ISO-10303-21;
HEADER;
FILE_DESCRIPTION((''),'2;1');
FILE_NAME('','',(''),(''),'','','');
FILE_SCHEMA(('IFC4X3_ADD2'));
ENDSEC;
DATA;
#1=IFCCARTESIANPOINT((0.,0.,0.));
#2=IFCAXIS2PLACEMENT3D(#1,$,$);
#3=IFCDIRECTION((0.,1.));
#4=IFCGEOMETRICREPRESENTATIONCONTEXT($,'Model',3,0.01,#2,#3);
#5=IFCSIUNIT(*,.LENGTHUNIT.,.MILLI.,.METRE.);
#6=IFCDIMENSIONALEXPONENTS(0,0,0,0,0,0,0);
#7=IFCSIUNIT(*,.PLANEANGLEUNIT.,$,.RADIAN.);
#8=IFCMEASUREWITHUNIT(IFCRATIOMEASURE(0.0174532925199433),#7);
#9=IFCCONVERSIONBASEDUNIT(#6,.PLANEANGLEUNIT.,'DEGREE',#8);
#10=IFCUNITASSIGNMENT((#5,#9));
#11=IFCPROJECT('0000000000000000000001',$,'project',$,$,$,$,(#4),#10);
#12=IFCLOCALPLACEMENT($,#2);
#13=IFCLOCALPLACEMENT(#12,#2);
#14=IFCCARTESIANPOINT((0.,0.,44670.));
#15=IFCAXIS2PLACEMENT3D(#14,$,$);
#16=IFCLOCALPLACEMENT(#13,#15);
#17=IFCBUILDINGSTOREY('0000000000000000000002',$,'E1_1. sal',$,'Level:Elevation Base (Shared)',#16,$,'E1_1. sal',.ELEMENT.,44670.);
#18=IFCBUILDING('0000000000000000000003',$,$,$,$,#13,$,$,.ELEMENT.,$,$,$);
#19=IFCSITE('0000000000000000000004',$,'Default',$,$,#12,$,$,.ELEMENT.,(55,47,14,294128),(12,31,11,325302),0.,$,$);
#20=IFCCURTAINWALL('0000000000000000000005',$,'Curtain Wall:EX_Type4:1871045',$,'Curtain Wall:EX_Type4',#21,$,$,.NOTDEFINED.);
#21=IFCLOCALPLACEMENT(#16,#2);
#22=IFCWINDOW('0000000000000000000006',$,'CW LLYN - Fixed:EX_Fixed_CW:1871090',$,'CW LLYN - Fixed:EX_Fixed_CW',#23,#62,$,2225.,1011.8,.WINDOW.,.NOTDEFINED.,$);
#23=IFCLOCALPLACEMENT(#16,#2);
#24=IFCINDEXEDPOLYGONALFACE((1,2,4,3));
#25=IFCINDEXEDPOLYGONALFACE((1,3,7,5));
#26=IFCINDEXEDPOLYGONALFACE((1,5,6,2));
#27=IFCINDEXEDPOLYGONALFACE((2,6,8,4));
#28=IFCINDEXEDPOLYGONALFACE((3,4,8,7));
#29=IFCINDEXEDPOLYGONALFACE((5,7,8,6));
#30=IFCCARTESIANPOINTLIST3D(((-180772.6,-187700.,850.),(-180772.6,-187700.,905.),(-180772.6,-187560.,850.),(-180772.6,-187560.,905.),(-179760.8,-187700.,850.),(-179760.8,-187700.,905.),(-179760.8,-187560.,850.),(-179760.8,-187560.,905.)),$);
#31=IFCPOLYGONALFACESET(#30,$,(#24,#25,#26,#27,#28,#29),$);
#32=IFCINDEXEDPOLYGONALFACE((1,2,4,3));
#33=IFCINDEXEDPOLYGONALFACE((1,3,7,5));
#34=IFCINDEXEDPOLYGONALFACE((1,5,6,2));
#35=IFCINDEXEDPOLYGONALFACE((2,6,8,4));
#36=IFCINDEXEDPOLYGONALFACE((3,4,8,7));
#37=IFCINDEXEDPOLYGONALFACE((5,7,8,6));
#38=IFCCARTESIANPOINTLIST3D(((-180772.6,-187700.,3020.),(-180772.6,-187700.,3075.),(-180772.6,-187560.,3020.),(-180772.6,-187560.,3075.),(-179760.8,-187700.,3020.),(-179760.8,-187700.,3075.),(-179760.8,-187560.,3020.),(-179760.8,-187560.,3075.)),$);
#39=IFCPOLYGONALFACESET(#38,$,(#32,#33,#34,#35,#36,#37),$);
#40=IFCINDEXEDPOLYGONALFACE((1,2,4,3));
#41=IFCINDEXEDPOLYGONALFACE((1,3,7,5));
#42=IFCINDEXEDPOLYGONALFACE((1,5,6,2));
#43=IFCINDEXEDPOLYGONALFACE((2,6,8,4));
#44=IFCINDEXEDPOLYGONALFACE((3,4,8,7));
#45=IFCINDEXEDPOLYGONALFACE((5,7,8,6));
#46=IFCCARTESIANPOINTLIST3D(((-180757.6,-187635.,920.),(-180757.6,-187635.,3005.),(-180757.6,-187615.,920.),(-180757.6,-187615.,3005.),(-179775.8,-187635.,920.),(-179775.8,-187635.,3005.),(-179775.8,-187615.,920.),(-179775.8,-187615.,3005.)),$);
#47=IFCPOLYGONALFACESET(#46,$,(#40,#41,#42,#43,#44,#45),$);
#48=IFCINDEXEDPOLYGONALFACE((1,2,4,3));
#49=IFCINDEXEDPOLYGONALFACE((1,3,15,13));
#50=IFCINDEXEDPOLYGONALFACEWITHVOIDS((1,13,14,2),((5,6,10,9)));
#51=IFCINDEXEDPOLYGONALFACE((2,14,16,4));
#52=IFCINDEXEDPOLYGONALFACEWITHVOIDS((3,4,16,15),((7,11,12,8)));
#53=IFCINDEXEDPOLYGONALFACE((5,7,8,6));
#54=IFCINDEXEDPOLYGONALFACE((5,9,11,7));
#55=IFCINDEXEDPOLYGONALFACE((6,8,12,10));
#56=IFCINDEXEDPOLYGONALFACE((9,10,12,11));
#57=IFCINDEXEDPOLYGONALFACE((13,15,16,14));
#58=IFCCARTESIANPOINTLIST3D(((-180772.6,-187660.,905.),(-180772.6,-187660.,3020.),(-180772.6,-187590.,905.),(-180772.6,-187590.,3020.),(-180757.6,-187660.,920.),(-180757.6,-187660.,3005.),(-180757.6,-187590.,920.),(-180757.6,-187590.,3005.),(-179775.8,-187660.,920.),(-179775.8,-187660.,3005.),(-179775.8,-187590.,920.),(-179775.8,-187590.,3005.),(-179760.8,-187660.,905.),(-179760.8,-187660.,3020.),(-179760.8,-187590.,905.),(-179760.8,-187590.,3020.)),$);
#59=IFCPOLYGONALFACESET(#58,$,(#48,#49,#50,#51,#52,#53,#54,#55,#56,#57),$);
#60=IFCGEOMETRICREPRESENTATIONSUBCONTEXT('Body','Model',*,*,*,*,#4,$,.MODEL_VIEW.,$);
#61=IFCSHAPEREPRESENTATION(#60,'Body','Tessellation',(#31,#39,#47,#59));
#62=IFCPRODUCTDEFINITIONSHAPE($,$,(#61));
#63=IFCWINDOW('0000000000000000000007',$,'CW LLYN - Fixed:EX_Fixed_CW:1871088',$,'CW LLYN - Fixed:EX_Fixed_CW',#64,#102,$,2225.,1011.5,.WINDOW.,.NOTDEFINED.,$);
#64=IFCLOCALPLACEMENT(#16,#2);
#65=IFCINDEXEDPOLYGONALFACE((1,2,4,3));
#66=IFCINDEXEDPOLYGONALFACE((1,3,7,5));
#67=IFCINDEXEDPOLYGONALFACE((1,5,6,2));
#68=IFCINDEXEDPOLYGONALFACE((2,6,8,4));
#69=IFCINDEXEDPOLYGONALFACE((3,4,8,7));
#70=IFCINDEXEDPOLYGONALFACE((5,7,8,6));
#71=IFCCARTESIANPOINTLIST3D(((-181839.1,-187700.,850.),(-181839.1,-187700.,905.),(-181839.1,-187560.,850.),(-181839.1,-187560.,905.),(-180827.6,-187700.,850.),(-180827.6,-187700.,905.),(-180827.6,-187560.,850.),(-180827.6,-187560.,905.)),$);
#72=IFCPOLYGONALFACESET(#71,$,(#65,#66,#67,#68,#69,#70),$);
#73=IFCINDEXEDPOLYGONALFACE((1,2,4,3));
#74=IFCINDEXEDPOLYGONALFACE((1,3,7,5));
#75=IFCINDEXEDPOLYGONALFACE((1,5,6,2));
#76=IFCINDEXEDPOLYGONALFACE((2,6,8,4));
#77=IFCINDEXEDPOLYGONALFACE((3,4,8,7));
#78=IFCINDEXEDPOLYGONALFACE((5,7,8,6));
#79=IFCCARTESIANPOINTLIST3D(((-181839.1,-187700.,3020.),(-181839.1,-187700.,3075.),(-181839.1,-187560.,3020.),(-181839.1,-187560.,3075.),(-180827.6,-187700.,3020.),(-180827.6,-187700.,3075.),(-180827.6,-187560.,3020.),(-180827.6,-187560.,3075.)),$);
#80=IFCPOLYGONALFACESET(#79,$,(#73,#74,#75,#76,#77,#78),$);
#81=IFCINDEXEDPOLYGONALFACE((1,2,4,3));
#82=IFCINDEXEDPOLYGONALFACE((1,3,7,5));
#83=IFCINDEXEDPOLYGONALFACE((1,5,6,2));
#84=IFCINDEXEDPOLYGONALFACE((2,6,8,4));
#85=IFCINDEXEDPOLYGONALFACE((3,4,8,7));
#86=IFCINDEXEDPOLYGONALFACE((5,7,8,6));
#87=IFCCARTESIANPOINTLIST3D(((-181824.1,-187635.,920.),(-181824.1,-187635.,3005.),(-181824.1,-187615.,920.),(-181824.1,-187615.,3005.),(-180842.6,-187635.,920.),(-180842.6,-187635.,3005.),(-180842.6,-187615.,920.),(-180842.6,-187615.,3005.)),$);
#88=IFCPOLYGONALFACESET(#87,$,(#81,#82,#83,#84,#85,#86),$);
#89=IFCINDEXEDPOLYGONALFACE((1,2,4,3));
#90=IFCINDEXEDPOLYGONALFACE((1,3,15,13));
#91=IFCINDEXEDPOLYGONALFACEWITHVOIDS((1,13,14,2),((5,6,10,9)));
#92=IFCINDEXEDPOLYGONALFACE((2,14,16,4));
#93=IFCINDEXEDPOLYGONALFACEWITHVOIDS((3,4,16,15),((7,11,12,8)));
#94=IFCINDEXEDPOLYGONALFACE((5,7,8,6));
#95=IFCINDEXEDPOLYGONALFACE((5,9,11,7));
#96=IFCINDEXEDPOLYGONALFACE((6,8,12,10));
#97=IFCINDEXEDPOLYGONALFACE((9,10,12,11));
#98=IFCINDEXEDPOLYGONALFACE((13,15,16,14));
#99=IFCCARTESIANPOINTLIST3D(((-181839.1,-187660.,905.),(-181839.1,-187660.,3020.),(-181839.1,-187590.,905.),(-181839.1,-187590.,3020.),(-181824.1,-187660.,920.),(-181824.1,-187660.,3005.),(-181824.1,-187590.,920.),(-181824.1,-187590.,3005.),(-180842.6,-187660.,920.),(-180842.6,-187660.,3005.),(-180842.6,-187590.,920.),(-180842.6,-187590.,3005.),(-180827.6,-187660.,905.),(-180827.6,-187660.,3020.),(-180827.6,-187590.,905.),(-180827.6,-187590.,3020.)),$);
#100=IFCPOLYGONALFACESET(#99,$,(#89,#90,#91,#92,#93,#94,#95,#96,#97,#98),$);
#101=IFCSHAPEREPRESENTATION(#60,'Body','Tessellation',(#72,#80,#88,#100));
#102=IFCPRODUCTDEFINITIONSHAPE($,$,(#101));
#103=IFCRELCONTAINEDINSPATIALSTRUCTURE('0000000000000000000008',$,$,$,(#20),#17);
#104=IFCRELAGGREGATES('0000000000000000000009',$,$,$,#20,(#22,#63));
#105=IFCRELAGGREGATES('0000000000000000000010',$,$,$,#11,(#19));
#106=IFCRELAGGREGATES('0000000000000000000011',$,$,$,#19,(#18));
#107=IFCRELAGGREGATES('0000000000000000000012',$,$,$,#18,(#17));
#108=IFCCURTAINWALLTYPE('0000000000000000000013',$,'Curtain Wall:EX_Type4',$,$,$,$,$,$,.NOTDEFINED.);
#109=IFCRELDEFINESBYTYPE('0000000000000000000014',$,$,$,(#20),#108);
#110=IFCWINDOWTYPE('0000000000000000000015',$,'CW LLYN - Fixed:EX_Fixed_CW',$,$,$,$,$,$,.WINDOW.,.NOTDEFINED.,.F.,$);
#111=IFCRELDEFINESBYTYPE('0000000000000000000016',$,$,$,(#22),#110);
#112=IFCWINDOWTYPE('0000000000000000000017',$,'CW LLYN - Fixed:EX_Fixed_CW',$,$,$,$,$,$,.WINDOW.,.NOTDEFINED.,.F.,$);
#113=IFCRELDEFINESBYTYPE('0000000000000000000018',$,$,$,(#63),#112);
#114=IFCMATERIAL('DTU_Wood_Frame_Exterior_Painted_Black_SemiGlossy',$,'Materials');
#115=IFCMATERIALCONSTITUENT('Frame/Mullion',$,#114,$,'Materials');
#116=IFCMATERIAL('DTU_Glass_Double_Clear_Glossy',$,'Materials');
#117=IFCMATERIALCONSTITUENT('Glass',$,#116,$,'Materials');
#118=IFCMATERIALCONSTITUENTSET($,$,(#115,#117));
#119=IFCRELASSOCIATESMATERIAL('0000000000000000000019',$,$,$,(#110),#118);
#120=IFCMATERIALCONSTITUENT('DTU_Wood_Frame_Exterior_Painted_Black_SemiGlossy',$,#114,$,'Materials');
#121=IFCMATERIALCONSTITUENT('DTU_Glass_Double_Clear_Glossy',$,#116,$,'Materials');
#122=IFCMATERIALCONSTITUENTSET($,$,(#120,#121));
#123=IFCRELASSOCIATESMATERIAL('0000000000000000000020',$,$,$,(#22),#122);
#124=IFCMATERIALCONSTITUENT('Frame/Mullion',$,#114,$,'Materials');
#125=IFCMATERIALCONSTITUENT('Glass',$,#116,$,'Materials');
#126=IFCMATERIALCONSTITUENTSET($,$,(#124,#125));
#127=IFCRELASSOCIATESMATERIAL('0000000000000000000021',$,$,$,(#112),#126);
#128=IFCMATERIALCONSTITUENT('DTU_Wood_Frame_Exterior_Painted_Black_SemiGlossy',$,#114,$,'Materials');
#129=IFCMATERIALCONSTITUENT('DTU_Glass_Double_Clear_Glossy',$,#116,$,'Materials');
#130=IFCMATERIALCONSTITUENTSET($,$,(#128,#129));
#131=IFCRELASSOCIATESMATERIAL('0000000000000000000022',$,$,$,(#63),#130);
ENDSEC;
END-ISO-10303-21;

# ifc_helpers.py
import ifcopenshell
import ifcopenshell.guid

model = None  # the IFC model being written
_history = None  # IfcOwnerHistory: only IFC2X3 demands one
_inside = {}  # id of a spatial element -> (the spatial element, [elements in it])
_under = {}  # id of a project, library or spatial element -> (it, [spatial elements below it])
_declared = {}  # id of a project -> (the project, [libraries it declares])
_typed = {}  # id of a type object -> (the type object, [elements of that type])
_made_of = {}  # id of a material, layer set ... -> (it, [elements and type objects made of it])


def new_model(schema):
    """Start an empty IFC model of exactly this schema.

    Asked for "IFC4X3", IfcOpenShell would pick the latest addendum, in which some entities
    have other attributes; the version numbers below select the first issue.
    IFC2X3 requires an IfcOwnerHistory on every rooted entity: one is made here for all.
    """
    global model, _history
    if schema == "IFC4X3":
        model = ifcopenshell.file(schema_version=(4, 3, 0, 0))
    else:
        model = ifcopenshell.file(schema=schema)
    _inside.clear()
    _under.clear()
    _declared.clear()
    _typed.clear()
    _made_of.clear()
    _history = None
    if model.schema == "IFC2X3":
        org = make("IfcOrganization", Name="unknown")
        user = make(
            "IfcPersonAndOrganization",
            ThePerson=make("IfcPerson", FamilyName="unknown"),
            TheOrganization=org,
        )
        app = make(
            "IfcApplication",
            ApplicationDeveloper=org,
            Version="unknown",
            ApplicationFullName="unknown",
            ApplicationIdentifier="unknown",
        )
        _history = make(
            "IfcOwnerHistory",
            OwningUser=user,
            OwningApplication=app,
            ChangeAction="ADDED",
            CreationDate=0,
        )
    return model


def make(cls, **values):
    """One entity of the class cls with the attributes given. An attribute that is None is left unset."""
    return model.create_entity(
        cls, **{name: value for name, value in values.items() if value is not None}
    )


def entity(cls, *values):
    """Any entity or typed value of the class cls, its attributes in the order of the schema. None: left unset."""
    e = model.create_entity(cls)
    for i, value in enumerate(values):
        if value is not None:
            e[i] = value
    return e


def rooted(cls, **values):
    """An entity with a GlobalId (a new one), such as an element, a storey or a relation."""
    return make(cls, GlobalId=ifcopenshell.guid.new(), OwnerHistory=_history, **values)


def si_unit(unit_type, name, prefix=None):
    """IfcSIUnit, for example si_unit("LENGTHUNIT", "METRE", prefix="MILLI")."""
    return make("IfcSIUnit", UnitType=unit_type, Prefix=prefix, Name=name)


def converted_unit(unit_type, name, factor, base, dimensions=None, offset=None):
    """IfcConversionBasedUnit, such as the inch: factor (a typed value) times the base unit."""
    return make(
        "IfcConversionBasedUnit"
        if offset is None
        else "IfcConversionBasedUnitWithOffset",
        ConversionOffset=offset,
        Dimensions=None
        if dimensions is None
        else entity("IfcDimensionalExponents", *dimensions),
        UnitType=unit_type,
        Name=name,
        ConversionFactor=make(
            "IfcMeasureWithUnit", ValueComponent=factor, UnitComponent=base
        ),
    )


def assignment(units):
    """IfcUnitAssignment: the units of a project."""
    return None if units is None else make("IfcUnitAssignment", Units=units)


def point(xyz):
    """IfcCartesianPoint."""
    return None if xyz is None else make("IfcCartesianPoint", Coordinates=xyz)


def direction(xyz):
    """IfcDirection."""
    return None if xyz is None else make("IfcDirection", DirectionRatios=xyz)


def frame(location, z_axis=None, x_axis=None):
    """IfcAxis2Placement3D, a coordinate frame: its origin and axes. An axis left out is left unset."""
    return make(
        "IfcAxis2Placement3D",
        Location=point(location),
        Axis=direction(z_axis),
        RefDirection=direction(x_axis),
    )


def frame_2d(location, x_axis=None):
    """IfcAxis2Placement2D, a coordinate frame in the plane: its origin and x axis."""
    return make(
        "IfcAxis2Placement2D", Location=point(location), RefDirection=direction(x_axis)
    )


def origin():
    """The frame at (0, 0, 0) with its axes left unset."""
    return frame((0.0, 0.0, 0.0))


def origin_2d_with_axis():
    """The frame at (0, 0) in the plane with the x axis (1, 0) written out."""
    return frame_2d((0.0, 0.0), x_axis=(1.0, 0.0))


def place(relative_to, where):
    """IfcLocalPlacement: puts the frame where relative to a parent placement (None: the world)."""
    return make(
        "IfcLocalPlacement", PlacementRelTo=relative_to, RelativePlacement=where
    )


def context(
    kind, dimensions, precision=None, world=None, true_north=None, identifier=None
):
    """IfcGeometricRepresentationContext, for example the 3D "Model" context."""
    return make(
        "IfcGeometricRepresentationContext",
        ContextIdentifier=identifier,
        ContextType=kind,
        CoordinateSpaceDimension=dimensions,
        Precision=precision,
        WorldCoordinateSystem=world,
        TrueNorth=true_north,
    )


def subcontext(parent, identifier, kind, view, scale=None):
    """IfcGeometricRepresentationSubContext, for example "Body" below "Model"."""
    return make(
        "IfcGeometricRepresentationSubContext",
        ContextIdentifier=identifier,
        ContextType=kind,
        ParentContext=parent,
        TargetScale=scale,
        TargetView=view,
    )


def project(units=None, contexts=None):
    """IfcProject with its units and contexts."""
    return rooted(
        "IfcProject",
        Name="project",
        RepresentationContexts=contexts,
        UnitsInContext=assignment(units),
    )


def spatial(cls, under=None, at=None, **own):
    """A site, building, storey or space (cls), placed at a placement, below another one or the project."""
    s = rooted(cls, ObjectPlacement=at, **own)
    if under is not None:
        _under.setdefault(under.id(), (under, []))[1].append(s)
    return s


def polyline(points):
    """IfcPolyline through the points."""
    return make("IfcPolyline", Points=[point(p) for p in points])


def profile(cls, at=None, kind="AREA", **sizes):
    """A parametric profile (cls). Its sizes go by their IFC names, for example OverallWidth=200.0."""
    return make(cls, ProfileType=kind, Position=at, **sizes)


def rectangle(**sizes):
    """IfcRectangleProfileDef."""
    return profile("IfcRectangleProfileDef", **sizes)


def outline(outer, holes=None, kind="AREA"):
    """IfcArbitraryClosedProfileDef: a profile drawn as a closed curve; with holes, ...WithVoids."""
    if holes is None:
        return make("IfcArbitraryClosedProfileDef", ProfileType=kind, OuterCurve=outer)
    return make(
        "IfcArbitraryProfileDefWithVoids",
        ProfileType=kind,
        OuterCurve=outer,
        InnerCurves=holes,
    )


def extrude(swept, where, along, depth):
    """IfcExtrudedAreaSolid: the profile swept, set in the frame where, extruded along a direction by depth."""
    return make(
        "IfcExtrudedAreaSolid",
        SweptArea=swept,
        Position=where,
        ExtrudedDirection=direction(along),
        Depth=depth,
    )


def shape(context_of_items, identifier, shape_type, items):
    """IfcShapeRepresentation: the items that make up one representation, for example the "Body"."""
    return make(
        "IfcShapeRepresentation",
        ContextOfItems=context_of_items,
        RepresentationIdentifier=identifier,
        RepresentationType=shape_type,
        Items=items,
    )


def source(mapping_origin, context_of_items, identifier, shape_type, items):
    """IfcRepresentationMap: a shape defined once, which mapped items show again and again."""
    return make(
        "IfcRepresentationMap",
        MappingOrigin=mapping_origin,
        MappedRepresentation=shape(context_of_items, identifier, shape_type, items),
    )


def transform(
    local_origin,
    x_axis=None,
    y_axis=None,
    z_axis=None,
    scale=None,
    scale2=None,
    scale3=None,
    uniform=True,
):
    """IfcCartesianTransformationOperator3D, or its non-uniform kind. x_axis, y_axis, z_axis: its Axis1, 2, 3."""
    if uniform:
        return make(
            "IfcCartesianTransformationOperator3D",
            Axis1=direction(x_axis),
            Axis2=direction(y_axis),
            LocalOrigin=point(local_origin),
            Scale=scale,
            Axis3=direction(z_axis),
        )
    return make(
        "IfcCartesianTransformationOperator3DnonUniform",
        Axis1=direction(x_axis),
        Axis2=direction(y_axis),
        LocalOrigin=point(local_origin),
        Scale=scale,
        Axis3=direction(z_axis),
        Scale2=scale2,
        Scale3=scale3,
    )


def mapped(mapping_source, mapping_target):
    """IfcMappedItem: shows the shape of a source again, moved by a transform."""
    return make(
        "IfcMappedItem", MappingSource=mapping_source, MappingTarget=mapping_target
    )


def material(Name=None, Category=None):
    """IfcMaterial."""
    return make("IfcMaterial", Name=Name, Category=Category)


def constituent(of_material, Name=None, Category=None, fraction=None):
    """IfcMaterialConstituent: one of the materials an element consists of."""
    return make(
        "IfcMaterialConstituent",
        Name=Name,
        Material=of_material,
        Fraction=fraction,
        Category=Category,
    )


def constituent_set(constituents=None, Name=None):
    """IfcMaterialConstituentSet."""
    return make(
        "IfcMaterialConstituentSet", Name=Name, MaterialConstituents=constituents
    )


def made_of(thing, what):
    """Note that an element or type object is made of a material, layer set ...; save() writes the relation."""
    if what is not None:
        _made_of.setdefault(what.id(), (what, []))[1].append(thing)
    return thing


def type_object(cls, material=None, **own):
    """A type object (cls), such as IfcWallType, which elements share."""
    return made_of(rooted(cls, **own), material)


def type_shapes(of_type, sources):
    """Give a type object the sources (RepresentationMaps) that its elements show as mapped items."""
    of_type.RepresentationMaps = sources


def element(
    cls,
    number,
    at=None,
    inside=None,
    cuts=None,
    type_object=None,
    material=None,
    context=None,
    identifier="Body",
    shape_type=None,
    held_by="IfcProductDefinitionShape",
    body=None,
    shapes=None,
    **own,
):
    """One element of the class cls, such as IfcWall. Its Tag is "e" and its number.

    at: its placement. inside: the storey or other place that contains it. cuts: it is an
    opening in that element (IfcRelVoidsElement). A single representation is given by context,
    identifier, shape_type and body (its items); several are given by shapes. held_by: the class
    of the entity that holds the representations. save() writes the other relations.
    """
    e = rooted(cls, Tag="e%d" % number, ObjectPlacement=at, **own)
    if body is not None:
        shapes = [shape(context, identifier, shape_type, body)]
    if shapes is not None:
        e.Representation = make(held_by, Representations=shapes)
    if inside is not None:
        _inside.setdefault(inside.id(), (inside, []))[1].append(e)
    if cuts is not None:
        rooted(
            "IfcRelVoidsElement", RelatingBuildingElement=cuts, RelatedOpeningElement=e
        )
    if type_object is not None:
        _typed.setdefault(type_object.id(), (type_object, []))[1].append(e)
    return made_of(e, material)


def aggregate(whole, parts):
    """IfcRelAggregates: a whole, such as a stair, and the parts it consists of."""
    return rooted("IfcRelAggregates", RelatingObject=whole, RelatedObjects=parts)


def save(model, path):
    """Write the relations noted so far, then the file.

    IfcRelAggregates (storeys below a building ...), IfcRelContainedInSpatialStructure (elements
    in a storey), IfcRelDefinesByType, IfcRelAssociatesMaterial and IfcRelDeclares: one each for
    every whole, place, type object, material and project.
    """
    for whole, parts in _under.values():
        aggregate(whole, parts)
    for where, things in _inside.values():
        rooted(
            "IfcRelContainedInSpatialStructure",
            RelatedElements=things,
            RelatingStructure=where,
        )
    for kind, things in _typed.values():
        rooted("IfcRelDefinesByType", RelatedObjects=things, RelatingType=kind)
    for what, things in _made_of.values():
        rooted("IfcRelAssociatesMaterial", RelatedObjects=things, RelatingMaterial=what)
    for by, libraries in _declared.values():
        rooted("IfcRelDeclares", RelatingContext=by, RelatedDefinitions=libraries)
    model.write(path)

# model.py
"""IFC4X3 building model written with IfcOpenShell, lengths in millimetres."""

from ifc_helpers import new_model, entity, si_unit, converted_unit, direction, frame, frame_2d, origin, origin_2d_with_axis, place, context, subcontext, project, spatial, polyline, rectangle, outline, extrude, source, transform, mapped, material, constituent, constituent_set, type_object, type_shapes, element, aggregate, save


model = new_model("IFC4X3")

# Units and contexts
model_context = context("Model", 3, precision=0.01, world=origin(), true_north=direction((0.0, 1.0)))
body_context = subcontext(model_context, "Body", "Model", "MODEL_VIEW")
ifc_project = project(units=[si_unit("LENGTHUNIT", "METRE", prefix="MILLI"), converted_unit("PLANEANGLEUNIT", "DEGREE", entity("IfcRatioMeasure", 0.0174532925199433), si_unit("PLANEANGLEUNIT", "RADIAN"), dimensions=[0, 0, 0, 0, 0, 0, 0])], contexts=[model_context])

# Site, building, storey
site_placement = place(None, origin())
site = spatial("IfcSite", under=ifc_project, at=site_placement, Name="Default", CompositionType="ELEMENT", RefLatitude=(55, 47, 14, 294128), RefLongitude=(12, 31, 11, 325302), RefElevation=0.0)
building_placement = place(site_placement, origin())
building = spatial("IfcBuilding", under=site, at=building_placement, CompositionType="ELEMENT")
storey_placement = place(building_placement, frame((0.0, 0.0, 44670.0)))
storey = spatial("IfcBuildingStorey", under=building, at=storey_placement, Name="E1_1. sal", ObjectType="Level:Elevation Base (Shared)", LongName="E1_1. sal", CompositionType="ELEMENT", Elevation=44670.0)

# Curtain wall
curtain_wall_type_1 = type_object("IfcCurtainWallType", Name="Curtain Wall:EX_Type4", PredefinedType="NOTDEFINED")
curtain_wall_1_placement = place(storey_placement, frame((0.0, 0.0, -44670.0)))
curtain_wall_1 = element("IfcCurtainWall", 1, at=curtain_wall_1_placement, inside=storey, type_object=curtain_wall_type_1, Name="Curtain Wall:EX_Type4:1871045", ObjectType="Curtain Wall:EX_Type4", PredefinedType="NOTDEFINED")

# Shared definitions
ifc_material_1 = material(Name="DTU_Wood_Frame_Exterior_Painted_Black_SemiGlossy", Category="Materials")
ifc_material_2 = material(Name="DTU_Glass_Double_Clear_Glossy", Category="Materials")

# Windows
ifc_constituent_1 = constituent(ifc_material_1, Name="DTU_Wood_Frame_Exterior_Painted_Black_SemiGlossy", Category="Materials")
ifc_constituent_2 = constituent(ifc_material_2, Name="DTU_Glass_Double_Clear_Glossy", Category="Materials")
ifc_constituent_set_1 = constituent_set(constituents=[ifc_constituent_1, ifc_constituent_2])
ifc_constituent_3 = constituent(ifc_material_1, Name="Frame/Mullion", Category="Materials")
ifc_constituent_4 = constituent(ifc_material_2, Name="Glass", Category="Materials")
ifc_constituent_set_2 = constituent_set(constituents=[ifc_constituent_3, ifc_constituent_4])
window_type_1 = type_object("IfcWindowType", Name="CW LLYN - Fixed:EX_Fixed_CW", ParameterTakesPrecedence=False, PartitioningType="NOTDEFINED", PredefinedType="WINDOW", material=ifc_constituent_set_2)
shared_shape_1 = source(origin(), body_context, "Body", "SweptSolid", [
    extrude(rectangle(XDim=140.0, YDim=1011.8, at=origin_2d_with_axis()), frame((0.0, -130.0, 0.0), z_axis=(0.0, 0.0, 1.0), x_axis=(0.0, -1.0, 0.0)), (0.0, 0.0, 1.0), 55.0),
    extrude(rectangle(XDim=140.0, YDim=1011.8, at=frame_2d((0.0, 0.0), x_axis=(1.0, 0.0))), frame((0.0, -130.0, 2170.0), z_axis=(0.0, 0.0, 1.0), x_axis=(0.0, -1.0, 0.0)), (0.0, 0.0, 1.0), 55.0),
    extrude(rectangle(XDim=981.8, YDim=20.0, at=frame_2d((0.0, 0.0), x_axis=(1.0, 0.0))), frame((0.0, -125.0, 70.0), z_axis=(0.0, 0.0, 1.0), x_axis=(-1.0, 0.0, 0.0)), (0.0, 0.0, 1.0), 2085.0),
    extrude(outline(polyline([(-1057.5, -505.9), (1057.5, -505.9), (1057.5, 505.9), (-1057.5, 505.9), (-1057.5, -505.9)]), holes=[polyline([(-1042.5, 490.9), (1042.5, 490.9), (1042.5, -490.9), (-1042.5, -490.9), (-1042.5, 490.9)])]), frame((0.0, -90.0, 1112.5), z_axis=(0.0, -1.0, 0.0), x_axis=(0.0, 0.0, 1.0)), (0.0, 0.0, 1.0), 70.0),
])
type_shapes(window_type_1, [shared_shape_1])
window_1_placement = place(curtain_wall_1_placement, frame((-180266.7, -187500.0, 45520.0)))
window_1 = element("IfcWindow", 2, at=window_1_placement, type_object=window_type_1, material=ifc_constituent_set_1, Name="CW LLYN - Fixed:EX_Fixed_CW:1871090", ObjectType="CW LLYN - Fixed:EX_Fixed_CW", OverallHeight=2225.0, OverallWidth=1011.8, PartitioningType="NOTDEFINED", PredefinedType="WINDOW", context=body_context, shape_type="MappedRepresentation", body=[
    mapped(shared_shape_1, transform((0.0, 0.0, 0.0), scale=1.0)),
])
ifc_constituent_5 = constituent(ifc_material_1, Name="DTU_Wood_Frame_Exterior_Painted_Black_SemiGlossy", Category="Materials")
ifc_constituent_6 = constituent(ifc_material_2, Name="DTU_Glass_Double_Clear_Glossy", Category="Materials")
ifc_constituent_set_3 = constituent_set(constituents=[ifc_constituent_5, ifc_constituent_6])
ifc_constituent_7 = constituent(ifc_material_1, Name="Frame/Mullion", Category="Materials")
ifc_constituent_8 = constituent(ifc_material_2, Name="Glass", Category="Materials")
ifc_constituent_set_4 = constituent_set(constituents=[ifc_constituent_7, ifc_constituent_8])
window_type_2 = type_object("IfcWindowType", Name="CW LLYN - Fixed:EX_Fixed_CW", ParameterTakesPrecedence=False, PartitioningType="NOTDEFINED", PredefinedType="WINDOW", material=ifc_constituent_set_4)
shared_shape_2 = source(origin(), body_context, "Body", "SweptSolid", [
    extrude(rectangle(XDim=140.0, YDim=1011.5, at=origin_2d_with_axis()), frame((0.0, -130.0, 0.0), z_axis=(0.0, 0.0, 1.0), x_axis=(0.0, -1.0, 0.0)), (0.0, 0.0, 1.0), 55.0),
    extrude(rectangle(XDim=140.0, YDim=1011.5, at=frame_2d((0.0, 0.0), x_axis=(1.0, 0.0))), frame((0.0, -130.0, 2170.0), z_axis=(0.0, 0.0, 1.0), x_axis=(0.0, -1.0, 0.0)), (0.0, 0.0, 1.0), 55.0),
    extrude(rectangle(XDim=981.5, YDim=20.0, at=origin_2d_with_axis()), frame((0.0, -125.0, 70.0), z_axis=(0.0, 0.0, 1.0), x_axis=(-1.0, 0.0, 0.0)), (0.0, 0.0, 1.0), 2085.0),
    extrude(outline(polyline([(-1057.5, -505.8), (1057.5, -505.8), (1057.5, 505.8), (-1057.5, 505.8), (-1057.5, -505.8)]), holes=[polyline([(-1042.5, 490.8), (1042.5, 490.8), (1042.5, -490.8), (-1042.5, -490.8), (-1042.5, 490.8)])]), frame((0.0, -90.0, 1112.5), z_axis=(0.0, -1.0, 0.0), x_axis=(0.0, 0.0, 1.0)), (0.0, 0.0, 1.0), 70.0),
])
type_shapes(window_type_2, [shared_shape_2])
window_2_placement = place(curtain_wall_1_placement, frame((-181333.3, -187500.0, 45520.0)))
window_2 = element("IfcWindow", 3, at=window_2_placement, type_object=window_type_2, material=ifc_constituent_set_3, Name="CW LLYN - Fixed:EX_Fixed_CW:1871088", ObjectType="CW LLYN - Fixed:EX_Fixed_CW", OverallHeight=2225.0, OverallWidth=1011.5, PartitioningType="NOTDEFINED", PredefinedType="WINDOW", context=body_context, shape_type="MappedRepresentation", body=[
    mapped(shared_shape_2, transform((0.0, 0.0, 0.0), scale=1.0)),
])
aggregate(curtain_wall_1, [window_1, window_2])

save(model, "model.ifc")
